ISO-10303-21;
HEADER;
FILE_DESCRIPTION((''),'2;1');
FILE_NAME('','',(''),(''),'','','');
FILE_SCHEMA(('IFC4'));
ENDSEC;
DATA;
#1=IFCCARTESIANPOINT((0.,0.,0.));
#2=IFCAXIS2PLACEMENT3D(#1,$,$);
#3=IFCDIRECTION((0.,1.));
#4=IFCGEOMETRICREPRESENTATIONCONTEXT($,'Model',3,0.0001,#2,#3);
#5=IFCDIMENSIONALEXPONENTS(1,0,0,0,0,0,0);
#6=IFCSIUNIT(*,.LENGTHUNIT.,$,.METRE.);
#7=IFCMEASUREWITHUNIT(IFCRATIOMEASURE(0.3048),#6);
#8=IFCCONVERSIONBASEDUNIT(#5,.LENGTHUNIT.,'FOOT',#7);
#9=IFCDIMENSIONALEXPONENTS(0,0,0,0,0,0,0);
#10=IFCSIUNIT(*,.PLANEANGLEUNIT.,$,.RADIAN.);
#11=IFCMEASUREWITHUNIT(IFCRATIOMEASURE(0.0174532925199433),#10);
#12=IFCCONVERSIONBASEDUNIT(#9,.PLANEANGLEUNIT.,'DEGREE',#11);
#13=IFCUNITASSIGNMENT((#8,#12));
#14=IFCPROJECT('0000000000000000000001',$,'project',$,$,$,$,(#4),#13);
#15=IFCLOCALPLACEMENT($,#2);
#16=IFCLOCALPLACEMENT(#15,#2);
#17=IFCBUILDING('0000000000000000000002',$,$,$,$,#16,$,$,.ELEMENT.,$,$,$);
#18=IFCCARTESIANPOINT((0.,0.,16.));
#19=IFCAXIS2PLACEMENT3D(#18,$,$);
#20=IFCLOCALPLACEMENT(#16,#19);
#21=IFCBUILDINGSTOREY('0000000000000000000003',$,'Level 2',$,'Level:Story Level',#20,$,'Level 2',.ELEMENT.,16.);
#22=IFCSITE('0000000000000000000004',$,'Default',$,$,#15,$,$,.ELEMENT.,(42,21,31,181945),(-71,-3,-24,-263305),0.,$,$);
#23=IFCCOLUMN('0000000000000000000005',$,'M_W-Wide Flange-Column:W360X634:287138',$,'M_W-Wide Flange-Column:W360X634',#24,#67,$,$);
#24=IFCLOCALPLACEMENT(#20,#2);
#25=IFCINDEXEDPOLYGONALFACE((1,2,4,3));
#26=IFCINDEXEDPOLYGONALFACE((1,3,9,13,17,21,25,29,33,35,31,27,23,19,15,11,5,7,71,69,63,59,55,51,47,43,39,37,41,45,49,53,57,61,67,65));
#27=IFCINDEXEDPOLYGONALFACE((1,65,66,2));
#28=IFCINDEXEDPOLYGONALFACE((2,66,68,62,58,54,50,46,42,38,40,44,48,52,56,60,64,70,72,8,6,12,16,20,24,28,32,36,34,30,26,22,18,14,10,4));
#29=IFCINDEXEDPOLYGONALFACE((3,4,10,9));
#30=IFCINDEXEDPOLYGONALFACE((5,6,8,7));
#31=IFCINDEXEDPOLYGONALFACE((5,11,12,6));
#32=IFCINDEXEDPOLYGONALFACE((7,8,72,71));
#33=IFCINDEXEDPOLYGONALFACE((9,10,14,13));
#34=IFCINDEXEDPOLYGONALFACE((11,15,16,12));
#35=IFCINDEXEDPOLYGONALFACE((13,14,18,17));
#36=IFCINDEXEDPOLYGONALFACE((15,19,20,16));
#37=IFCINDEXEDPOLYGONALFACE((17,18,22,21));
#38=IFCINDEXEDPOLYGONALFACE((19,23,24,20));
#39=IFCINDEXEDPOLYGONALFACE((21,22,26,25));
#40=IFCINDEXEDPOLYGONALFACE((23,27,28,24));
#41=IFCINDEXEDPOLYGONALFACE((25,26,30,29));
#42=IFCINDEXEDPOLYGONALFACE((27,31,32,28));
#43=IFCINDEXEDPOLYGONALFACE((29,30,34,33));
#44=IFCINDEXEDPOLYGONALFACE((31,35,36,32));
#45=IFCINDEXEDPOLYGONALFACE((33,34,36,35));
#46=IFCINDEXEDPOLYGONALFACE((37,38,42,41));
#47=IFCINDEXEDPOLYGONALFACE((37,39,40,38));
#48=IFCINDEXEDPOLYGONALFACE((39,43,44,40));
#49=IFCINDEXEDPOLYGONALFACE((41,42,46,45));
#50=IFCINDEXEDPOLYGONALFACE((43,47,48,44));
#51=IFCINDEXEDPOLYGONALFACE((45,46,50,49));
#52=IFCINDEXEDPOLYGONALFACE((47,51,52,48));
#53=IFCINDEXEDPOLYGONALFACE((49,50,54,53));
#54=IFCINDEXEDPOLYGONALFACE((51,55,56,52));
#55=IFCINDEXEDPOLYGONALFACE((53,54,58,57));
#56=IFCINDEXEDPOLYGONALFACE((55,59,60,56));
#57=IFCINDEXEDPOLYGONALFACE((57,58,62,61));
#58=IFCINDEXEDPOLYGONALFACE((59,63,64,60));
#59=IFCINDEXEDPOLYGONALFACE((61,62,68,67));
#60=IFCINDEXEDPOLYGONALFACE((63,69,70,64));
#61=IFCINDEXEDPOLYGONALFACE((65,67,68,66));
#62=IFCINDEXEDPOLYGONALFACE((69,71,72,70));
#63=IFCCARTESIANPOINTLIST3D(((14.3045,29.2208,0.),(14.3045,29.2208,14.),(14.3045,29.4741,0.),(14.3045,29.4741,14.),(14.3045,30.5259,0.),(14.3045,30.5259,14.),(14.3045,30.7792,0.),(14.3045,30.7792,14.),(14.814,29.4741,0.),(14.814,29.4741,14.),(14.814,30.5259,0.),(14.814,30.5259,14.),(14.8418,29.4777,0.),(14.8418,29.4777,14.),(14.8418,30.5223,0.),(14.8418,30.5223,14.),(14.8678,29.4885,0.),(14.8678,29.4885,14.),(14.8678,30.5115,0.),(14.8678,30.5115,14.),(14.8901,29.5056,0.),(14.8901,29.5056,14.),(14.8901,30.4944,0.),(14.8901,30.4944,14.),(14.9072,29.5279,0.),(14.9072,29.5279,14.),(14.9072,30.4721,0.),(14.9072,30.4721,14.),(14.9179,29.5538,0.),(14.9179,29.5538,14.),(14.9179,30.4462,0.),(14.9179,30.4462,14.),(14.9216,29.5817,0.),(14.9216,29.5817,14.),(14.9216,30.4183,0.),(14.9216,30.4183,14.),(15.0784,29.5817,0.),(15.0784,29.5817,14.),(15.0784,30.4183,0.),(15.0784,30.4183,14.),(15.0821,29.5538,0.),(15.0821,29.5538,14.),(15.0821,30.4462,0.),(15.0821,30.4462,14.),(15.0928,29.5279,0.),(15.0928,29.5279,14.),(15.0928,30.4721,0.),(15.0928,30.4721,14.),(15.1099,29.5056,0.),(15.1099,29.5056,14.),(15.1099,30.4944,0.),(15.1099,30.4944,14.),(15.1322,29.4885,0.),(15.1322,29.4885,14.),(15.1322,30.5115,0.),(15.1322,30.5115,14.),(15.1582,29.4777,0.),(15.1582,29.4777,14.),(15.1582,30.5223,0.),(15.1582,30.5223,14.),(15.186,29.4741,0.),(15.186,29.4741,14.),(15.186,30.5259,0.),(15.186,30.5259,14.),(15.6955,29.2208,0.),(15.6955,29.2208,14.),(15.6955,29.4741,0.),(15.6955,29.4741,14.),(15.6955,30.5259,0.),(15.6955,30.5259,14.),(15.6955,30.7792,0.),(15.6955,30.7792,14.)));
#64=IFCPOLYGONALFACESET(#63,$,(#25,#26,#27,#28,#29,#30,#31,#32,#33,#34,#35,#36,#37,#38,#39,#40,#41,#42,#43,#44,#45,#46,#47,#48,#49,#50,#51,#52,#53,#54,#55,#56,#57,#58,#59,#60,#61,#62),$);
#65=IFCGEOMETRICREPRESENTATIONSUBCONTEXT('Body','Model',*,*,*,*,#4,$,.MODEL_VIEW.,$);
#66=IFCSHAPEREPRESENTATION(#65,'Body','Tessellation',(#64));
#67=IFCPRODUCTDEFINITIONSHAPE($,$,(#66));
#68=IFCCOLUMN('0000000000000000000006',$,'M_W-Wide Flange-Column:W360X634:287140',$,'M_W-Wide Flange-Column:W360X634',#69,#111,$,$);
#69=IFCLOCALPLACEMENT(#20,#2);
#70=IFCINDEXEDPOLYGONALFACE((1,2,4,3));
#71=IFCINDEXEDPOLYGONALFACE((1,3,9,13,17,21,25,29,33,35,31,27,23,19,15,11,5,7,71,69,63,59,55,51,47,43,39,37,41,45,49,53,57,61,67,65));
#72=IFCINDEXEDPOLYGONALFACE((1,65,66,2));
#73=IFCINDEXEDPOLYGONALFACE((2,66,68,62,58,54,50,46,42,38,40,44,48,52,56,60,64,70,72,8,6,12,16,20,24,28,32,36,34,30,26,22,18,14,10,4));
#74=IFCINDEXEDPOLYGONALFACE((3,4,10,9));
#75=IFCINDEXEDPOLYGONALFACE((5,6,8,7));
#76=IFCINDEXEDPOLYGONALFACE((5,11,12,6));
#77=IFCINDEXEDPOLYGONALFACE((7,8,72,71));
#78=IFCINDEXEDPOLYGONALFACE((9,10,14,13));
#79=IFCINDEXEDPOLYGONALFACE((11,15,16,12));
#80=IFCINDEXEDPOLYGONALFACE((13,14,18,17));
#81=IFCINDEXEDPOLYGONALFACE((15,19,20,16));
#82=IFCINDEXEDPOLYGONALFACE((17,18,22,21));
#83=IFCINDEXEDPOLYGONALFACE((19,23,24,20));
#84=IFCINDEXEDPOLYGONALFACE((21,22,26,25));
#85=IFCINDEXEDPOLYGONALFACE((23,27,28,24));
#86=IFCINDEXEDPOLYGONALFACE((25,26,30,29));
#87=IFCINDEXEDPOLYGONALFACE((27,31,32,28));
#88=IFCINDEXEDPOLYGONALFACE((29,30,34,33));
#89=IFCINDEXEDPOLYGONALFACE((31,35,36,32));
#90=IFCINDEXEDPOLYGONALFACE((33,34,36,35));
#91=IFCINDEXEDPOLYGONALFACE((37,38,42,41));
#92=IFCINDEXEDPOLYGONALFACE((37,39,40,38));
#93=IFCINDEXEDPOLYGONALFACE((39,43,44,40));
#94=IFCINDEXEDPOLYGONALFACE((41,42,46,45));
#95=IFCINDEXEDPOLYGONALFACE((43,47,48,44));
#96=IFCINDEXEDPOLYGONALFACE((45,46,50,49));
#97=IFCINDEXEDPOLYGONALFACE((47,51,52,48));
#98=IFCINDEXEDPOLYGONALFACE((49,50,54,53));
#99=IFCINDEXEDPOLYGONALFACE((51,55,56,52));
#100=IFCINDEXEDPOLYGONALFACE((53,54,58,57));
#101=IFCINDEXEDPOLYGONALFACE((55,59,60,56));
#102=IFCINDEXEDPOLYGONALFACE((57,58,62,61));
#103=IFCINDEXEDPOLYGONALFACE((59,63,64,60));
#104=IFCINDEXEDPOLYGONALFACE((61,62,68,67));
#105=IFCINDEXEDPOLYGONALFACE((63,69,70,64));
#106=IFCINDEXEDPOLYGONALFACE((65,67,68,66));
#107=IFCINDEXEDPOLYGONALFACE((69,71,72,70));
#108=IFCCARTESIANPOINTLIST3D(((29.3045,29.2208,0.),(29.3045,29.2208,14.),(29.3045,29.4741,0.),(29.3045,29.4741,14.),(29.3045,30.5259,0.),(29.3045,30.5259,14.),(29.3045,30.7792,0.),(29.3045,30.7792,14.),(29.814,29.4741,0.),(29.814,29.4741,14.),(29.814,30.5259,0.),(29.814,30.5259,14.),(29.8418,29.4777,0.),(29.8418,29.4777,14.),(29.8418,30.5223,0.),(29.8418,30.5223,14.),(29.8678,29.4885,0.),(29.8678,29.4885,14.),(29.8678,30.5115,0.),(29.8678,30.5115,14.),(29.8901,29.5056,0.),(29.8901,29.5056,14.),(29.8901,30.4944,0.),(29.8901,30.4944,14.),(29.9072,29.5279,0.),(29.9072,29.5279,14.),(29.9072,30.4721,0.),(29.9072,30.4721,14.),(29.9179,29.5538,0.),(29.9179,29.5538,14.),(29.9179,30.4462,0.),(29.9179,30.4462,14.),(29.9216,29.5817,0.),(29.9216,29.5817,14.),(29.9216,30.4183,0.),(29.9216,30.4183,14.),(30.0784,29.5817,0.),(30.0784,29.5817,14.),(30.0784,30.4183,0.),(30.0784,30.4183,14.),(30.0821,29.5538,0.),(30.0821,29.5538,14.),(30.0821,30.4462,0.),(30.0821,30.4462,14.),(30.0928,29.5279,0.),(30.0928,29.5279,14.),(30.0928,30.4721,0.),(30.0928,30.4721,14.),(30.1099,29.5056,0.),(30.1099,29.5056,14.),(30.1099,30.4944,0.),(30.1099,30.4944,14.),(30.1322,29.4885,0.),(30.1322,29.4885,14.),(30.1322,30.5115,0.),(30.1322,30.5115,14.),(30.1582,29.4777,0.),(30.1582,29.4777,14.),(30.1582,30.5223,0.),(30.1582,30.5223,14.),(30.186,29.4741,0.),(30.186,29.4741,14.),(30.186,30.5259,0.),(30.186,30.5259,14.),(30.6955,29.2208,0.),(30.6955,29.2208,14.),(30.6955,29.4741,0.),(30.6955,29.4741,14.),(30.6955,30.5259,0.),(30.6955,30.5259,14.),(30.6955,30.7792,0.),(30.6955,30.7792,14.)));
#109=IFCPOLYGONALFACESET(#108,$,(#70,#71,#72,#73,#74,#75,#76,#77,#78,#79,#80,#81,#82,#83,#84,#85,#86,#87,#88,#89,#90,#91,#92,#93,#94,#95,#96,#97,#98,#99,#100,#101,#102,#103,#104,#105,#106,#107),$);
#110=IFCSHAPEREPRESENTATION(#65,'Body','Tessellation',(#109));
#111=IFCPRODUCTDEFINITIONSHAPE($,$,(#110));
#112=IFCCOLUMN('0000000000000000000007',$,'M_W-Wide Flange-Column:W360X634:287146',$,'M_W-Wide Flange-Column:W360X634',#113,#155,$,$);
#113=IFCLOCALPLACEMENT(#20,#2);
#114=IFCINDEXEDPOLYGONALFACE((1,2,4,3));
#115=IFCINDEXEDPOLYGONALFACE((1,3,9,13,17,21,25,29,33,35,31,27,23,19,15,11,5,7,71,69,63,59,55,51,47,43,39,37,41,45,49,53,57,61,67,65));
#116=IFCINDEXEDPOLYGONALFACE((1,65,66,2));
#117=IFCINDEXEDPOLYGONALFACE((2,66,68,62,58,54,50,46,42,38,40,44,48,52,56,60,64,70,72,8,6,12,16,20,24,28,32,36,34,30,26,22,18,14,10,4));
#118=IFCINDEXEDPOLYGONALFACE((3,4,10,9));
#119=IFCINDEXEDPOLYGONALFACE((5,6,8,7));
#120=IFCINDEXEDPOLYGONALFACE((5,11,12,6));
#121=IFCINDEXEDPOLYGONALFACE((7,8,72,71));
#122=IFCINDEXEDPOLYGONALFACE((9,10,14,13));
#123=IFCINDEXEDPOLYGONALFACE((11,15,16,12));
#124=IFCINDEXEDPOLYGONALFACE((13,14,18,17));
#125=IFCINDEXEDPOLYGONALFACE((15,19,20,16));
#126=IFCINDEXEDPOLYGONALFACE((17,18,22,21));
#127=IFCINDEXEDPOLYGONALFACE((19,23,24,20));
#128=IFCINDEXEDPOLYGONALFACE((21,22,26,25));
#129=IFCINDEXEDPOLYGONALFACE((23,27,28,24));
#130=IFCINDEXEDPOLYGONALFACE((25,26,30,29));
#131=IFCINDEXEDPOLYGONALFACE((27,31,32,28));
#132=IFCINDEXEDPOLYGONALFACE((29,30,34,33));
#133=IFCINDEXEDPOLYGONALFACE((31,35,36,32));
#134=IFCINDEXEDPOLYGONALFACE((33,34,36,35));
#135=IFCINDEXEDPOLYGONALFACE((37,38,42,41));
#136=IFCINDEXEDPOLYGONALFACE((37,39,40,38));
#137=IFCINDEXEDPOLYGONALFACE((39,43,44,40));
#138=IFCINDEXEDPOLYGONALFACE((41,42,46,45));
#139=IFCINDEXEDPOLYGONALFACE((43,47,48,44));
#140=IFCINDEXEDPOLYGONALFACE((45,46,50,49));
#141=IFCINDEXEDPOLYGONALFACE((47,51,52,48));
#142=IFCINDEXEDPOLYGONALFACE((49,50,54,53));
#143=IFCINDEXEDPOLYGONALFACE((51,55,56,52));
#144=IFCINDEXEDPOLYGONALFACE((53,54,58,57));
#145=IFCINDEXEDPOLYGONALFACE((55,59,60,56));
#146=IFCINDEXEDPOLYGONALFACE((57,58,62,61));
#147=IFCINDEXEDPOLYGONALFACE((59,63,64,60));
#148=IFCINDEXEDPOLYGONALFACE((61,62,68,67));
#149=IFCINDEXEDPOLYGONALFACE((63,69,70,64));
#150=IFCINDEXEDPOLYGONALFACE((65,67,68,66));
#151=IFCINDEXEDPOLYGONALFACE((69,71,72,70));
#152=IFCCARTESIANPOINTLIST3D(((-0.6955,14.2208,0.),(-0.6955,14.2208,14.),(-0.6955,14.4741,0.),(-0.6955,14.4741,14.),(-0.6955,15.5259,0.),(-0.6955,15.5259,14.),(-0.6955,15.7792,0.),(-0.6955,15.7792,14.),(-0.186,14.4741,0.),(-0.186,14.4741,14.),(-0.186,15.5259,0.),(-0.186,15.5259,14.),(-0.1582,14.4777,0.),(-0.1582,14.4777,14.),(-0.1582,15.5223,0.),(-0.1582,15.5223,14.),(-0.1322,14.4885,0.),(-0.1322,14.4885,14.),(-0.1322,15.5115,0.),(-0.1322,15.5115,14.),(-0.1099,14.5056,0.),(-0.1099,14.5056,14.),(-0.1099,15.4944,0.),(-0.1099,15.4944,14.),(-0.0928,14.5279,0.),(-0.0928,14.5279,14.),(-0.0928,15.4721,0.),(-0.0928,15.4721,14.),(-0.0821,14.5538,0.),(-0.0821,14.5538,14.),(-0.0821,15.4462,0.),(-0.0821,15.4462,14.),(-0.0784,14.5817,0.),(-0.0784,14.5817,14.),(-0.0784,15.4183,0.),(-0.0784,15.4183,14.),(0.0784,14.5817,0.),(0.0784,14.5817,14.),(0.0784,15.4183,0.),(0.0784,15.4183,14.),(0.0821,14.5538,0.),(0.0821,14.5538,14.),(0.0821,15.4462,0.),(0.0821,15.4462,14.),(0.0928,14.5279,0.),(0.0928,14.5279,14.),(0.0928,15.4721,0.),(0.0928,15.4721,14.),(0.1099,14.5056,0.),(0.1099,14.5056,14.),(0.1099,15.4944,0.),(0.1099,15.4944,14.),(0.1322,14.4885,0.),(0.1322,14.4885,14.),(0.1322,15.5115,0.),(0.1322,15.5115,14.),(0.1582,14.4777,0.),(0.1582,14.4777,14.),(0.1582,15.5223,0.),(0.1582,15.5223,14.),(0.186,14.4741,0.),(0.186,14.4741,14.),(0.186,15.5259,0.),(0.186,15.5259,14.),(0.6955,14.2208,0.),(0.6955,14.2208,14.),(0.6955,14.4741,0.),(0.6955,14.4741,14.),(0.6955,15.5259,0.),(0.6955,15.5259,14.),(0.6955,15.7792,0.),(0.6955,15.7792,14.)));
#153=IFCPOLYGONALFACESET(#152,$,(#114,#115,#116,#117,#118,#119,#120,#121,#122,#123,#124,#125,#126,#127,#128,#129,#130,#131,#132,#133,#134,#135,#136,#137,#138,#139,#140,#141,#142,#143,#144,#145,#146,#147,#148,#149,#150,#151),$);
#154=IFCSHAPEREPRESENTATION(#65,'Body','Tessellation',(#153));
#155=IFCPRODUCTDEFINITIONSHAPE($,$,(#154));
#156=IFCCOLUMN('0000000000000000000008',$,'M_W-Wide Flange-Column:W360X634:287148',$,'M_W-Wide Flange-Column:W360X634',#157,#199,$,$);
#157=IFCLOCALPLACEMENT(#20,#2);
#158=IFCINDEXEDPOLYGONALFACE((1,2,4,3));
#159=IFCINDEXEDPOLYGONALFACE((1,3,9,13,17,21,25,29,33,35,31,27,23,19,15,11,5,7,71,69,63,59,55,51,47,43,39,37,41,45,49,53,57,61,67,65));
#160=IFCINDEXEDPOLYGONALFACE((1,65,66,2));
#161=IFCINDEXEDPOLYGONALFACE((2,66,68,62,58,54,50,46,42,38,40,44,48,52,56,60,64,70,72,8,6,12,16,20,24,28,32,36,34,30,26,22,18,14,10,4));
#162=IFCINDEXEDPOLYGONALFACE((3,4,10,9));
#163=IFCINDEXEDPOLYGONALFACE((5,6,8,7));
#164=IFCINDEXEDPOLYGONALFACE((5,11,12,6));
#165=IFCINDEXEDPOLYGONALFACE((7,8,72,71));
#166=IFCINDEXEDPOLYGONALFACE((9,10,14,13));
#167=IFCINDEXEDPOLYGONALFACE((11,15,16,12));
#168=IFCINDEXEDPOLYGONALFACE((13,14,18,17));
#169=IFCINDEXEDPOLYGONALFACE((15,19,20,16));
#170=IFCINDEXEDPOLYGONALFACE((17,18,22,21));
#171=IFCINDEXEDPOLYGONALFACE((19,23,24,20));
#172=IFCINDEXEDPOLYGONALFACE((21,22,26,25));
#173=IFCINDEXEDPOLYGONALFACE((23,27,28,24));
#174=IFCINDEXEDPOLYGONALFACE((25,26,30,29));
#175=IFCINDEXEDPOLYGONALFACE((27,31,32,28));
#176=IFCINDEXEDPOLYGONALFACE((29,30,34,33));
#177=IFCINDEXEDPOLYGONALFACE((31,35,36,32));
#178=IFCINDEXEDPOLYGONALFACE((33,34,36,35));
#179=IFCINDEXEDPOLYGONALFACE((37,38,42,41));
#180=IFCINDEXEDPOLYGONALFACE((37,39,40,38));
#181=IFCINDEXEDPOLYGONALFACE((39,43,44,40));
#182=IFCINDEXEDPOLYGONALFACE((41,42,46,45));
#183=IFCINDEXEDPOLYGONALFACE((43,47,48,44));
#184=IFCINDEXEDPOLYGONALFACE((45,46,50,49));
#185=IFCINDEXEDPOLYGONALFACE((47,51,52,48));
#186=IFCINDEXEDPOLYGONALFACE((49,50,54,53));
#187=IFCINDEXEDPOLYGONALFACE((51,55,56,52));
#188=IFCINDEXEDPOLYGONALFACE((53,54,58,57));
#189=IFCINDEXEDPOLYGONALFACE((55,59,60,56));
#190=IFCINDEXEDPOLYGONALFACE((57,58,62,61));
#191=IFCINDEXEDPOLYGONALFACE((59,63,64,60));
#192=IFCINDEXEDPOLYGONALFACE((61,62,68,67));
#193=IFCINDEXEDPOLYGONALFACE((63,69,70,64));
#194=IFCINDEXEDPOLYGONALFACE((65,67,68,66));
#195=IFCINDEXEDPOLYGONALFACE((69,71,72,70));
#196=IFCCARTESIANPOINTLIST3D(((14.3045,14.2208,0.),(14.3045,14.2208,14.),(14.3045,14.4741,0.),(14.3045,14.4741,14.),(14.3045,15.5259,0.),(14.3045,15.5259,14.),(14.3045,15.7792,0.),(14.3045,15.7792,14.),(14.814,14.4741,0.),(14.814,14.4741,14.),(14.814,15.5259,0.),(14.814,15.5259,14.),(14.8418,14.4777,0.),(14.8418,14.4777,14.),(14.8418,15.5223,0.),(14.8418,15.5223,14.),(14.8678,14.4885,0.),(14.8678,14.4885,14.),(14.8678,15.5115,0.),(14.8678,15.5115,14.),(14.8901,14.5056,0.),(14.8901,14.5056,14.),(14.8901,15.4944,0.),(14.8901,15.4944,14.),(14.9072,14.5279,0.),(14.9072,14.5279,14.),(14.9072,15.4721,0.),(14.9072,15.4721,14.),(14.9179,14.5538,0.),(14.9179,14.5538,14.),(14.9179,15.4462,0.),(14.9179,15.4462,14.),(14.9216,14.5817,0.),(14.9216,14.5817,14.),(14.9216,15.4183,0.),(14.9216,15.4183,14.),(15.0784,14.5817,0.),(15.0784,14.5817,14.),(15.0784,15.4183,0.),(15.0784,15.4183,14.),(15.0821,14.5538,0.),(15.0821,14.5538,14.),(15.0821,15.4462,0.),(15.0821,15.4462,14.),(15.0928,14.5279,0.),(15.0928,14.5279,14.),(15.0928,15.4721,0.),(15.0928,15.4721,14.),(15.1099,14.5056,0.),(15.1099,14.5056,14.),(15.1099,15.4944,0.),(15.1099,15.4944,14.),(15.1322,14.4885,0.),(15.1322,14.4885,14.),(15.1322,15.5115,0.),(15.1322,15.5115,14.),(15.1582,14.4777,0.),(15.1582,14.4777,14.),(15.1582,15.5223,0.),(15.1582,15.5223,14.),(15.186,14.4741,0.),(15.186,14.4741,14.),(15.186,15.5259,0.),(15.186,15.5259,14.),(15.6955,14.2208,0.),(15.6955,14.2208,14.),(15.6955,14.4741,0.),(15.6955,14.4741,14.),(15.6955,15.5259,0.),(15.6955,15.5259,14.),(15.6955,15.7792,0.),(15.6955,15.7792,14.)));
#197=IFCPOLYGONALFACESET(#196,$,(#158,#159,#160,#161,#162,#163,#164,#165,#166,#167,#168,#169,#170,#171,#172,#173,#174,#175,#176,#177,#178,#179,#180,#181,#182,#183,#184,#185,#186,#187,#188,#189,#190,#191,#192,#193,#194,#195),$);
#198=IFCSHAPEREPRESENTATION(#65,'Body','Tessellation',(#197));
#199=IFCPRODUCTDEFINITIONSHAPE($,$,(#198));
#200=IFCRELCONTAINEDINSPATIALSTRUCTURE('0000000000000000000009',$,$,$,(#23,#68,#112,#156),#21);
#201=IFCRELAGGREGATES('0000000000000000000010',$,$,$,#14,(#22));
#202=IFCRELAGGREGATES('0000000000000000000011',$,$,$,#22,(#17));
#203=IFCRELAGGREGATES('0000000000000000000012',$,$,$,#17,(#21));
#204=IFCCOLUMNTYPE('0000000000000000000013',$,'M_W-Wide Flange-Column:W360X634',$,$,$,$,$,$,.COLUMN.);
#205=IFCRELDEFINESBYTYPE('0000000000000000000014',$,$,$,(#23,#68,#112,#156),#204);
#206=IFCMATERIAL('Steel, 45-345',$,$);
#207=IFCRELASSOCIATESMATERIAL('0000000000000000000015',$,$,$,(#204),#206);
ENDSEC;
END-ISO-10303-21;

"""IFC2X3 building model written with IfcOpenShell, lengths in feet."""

from ifc_helpers import new_model, entity, si_unit, converted_unit, direction, frame, frame_2d, origin, place, context, subcontext, project, spatial, polyline, circle_curve, parameter, trimmed, segment, composite_curve, outline, extrude, source, transform, mapped, material, type_object, type_shapes, element, save


model = new_model("IFC2X3")

# Units and contexts
model_context = context("Model", 3, precision=0.0001, world=origin(), true_north=direction((0.0, 1.0)))
body_context = subcontext(model_context, "Body", "Model", "MODEL_VIEW")
ifc_project = project(units=[converted_unit("LENGTHUNIT", "FOOT", entity("IfcRatioMeasure", 0.3048), si_unit("LENGTHUNIT", "METRE"), dimensions=[1, 0, 0, 0, 0, 0, 0]), converted_unit("PLANEANGLEUNIT", "DEGREE", entity("IfcRatioMeasure", 0.0174532925199433), si_unit("PLANEANGLEUNIT", "RADIAN"), dimensions=[0, 0, 0, 0, 0, 0, 0])], contexts=[model_context])

# Site, building, storey
site_placement = place(None, origin())
site = spatial("IfcSite", under=ifc_project, at=site_placement, Name="Default", CompositionType="ELEMENT", RefLatitude=(42, 21, 31, 181945), RefLongitude=(-71, -3, -24, -263305), RefElevation=0.0)
building_placement = place(site_placement, origin())
building = spatial("IfcBuilding", under=site, at=building_placement, CompositionType="ELEMENT")
storey_placement = place(building_placement, frame((0.0, 0.0, 16.0)))
storey = spatial("IfcBuildingStorey", under=building, at=storey_placement, Name="Level 2", ObjectType="Level:Story Level", LongName="Level 2", CompositionType="ELEMENT", Elevation=16.0)

# Columns
ifc_material = material(Name="Steel, 45-345")
column_type = type_object("IfcColumnType", Name="M_W-Wide Flange-Column:W360X634", PredefinedType="COLUMN", material=ifc_material)
shared_shape = source(origin(), body_context, "Body", "SweptSolid", [
    extrude(outline(composite_curve([segment(polyline([(0.5259, -0.6955), (0.7792, -0.6955)]), True, "CONTINUOUS"), segment(polyline([(0.7792, -0.6955), (0.7792, 0.6955)]), True, "CONTINUOUS"), segment(polyline([(0.7792, 0.6955), (0.5259, 0.6955)]), True, "CONTINUOUS"), segment(polyline([(0.5259, 0.6955), (0.5259, 0.186)]), True, "CONTINUOUS"), segment(trimmed(circle_curve(frame_2d((0.4183, 0.186), x_axis=(1.0, 0.0)), 0.1076), [parameter(270.0)], [parameter(0.0)], True, "PARAMETER"), False, "CONTINUOUS"), segment(polyline([(0.4183, 0.0784), (-0.4183, 0.0784)]), True, "CONTINUOUS"), segment(trimmed(circle_curve(frame_2d((-0.4183, 0.186), x_axis=(0.0, -1.0)), 0.1076), [parameter(270.0)], [parameter(0.0)], True, "PARAMETER"), False, "CONTINUOUS"), segment(polyline([(-0.5259, 0.186), (-0.5259, 0.6955)]), True, "CONTINUOUS"), segment(polyline([(-0.5259, 0.6955), (-0.7792, 0.6955)]), True, "CONTINUOUS"), segment(polyline([(-0.7792, 0.6955), (-0.7792, -0.6955)]), True, "CONTINUOUS"), segment(polyline([(-0.7792, -0.6955), (-0.5259, -0.6955)]), True, "CONTINUOUS"), segment(polyline([(-0.5259, -0.6955), (-0.5259, -0.186)]), True, "CONTINUOUS"), segment(trimmed(circle_curve(frame_2d((-0.4183, -0.186), x_axis=(-1.0, 0.0)), 0.1076), [parameter(270.0)], [parameter(0.0)], True, "PARAMETER"), False, "CONTINUOUS"), segment(polyline([(-0.4183, -0.0784), (0.4183, -0.0784)]), True, "CONTINUOUS"), segment(trimmed(circle_curve(frame_2d((0.4183, -0.186), x_axis=(0.0, 1.0)), 0.1076), [parameter(270.0)], [parameter(0.0)], True, "PARAMETER"), False, "CONTINUOUS"), segment(polyline([(0.5259, -0.186), (0.5259, -0.6955)]), True, "CONTINUOUS")], self_intersect=False)), frame((0.0, 0.0, 16.0), z_axis=(0.0, 0.0, 1.0), x_axis=(0.0, -1.0, 0.0)), (0.0, 0.0, 1.0), 14.0),
])
type_shapes(column_type, [shared_shape])
for number, where, name in (
    (1, (15.0, 30.0, -16.0), "M_W-Wide Flange-Column:W360X634:287138"),
    (2, (30.0, 30.0, -16.0), "M_W-Wide Flange-Column:W360X634:287140"),
    (3, (0.0, 15.0, -16.0), "M_W-Wide Flange-Column:W360X634:287146"),
    (4, (15.0, 15.0, -16.0), "M_W-Wide Flange-Column:W360X634:287148"),
):
    element("IfcColumn", number, at=place(storey_placement, frame(where)), inside=storey, type_object=column_type, Name=name, ObjectType="M_W-Wide Flange-Column:W360X634", context=body_context, shape_type="MappedRepresentation", body=[
        mapped(shared_shape, transform((0.0, 0.0, 0.0), scale=1.0)),
    ])

save(model, "model.ifc")
